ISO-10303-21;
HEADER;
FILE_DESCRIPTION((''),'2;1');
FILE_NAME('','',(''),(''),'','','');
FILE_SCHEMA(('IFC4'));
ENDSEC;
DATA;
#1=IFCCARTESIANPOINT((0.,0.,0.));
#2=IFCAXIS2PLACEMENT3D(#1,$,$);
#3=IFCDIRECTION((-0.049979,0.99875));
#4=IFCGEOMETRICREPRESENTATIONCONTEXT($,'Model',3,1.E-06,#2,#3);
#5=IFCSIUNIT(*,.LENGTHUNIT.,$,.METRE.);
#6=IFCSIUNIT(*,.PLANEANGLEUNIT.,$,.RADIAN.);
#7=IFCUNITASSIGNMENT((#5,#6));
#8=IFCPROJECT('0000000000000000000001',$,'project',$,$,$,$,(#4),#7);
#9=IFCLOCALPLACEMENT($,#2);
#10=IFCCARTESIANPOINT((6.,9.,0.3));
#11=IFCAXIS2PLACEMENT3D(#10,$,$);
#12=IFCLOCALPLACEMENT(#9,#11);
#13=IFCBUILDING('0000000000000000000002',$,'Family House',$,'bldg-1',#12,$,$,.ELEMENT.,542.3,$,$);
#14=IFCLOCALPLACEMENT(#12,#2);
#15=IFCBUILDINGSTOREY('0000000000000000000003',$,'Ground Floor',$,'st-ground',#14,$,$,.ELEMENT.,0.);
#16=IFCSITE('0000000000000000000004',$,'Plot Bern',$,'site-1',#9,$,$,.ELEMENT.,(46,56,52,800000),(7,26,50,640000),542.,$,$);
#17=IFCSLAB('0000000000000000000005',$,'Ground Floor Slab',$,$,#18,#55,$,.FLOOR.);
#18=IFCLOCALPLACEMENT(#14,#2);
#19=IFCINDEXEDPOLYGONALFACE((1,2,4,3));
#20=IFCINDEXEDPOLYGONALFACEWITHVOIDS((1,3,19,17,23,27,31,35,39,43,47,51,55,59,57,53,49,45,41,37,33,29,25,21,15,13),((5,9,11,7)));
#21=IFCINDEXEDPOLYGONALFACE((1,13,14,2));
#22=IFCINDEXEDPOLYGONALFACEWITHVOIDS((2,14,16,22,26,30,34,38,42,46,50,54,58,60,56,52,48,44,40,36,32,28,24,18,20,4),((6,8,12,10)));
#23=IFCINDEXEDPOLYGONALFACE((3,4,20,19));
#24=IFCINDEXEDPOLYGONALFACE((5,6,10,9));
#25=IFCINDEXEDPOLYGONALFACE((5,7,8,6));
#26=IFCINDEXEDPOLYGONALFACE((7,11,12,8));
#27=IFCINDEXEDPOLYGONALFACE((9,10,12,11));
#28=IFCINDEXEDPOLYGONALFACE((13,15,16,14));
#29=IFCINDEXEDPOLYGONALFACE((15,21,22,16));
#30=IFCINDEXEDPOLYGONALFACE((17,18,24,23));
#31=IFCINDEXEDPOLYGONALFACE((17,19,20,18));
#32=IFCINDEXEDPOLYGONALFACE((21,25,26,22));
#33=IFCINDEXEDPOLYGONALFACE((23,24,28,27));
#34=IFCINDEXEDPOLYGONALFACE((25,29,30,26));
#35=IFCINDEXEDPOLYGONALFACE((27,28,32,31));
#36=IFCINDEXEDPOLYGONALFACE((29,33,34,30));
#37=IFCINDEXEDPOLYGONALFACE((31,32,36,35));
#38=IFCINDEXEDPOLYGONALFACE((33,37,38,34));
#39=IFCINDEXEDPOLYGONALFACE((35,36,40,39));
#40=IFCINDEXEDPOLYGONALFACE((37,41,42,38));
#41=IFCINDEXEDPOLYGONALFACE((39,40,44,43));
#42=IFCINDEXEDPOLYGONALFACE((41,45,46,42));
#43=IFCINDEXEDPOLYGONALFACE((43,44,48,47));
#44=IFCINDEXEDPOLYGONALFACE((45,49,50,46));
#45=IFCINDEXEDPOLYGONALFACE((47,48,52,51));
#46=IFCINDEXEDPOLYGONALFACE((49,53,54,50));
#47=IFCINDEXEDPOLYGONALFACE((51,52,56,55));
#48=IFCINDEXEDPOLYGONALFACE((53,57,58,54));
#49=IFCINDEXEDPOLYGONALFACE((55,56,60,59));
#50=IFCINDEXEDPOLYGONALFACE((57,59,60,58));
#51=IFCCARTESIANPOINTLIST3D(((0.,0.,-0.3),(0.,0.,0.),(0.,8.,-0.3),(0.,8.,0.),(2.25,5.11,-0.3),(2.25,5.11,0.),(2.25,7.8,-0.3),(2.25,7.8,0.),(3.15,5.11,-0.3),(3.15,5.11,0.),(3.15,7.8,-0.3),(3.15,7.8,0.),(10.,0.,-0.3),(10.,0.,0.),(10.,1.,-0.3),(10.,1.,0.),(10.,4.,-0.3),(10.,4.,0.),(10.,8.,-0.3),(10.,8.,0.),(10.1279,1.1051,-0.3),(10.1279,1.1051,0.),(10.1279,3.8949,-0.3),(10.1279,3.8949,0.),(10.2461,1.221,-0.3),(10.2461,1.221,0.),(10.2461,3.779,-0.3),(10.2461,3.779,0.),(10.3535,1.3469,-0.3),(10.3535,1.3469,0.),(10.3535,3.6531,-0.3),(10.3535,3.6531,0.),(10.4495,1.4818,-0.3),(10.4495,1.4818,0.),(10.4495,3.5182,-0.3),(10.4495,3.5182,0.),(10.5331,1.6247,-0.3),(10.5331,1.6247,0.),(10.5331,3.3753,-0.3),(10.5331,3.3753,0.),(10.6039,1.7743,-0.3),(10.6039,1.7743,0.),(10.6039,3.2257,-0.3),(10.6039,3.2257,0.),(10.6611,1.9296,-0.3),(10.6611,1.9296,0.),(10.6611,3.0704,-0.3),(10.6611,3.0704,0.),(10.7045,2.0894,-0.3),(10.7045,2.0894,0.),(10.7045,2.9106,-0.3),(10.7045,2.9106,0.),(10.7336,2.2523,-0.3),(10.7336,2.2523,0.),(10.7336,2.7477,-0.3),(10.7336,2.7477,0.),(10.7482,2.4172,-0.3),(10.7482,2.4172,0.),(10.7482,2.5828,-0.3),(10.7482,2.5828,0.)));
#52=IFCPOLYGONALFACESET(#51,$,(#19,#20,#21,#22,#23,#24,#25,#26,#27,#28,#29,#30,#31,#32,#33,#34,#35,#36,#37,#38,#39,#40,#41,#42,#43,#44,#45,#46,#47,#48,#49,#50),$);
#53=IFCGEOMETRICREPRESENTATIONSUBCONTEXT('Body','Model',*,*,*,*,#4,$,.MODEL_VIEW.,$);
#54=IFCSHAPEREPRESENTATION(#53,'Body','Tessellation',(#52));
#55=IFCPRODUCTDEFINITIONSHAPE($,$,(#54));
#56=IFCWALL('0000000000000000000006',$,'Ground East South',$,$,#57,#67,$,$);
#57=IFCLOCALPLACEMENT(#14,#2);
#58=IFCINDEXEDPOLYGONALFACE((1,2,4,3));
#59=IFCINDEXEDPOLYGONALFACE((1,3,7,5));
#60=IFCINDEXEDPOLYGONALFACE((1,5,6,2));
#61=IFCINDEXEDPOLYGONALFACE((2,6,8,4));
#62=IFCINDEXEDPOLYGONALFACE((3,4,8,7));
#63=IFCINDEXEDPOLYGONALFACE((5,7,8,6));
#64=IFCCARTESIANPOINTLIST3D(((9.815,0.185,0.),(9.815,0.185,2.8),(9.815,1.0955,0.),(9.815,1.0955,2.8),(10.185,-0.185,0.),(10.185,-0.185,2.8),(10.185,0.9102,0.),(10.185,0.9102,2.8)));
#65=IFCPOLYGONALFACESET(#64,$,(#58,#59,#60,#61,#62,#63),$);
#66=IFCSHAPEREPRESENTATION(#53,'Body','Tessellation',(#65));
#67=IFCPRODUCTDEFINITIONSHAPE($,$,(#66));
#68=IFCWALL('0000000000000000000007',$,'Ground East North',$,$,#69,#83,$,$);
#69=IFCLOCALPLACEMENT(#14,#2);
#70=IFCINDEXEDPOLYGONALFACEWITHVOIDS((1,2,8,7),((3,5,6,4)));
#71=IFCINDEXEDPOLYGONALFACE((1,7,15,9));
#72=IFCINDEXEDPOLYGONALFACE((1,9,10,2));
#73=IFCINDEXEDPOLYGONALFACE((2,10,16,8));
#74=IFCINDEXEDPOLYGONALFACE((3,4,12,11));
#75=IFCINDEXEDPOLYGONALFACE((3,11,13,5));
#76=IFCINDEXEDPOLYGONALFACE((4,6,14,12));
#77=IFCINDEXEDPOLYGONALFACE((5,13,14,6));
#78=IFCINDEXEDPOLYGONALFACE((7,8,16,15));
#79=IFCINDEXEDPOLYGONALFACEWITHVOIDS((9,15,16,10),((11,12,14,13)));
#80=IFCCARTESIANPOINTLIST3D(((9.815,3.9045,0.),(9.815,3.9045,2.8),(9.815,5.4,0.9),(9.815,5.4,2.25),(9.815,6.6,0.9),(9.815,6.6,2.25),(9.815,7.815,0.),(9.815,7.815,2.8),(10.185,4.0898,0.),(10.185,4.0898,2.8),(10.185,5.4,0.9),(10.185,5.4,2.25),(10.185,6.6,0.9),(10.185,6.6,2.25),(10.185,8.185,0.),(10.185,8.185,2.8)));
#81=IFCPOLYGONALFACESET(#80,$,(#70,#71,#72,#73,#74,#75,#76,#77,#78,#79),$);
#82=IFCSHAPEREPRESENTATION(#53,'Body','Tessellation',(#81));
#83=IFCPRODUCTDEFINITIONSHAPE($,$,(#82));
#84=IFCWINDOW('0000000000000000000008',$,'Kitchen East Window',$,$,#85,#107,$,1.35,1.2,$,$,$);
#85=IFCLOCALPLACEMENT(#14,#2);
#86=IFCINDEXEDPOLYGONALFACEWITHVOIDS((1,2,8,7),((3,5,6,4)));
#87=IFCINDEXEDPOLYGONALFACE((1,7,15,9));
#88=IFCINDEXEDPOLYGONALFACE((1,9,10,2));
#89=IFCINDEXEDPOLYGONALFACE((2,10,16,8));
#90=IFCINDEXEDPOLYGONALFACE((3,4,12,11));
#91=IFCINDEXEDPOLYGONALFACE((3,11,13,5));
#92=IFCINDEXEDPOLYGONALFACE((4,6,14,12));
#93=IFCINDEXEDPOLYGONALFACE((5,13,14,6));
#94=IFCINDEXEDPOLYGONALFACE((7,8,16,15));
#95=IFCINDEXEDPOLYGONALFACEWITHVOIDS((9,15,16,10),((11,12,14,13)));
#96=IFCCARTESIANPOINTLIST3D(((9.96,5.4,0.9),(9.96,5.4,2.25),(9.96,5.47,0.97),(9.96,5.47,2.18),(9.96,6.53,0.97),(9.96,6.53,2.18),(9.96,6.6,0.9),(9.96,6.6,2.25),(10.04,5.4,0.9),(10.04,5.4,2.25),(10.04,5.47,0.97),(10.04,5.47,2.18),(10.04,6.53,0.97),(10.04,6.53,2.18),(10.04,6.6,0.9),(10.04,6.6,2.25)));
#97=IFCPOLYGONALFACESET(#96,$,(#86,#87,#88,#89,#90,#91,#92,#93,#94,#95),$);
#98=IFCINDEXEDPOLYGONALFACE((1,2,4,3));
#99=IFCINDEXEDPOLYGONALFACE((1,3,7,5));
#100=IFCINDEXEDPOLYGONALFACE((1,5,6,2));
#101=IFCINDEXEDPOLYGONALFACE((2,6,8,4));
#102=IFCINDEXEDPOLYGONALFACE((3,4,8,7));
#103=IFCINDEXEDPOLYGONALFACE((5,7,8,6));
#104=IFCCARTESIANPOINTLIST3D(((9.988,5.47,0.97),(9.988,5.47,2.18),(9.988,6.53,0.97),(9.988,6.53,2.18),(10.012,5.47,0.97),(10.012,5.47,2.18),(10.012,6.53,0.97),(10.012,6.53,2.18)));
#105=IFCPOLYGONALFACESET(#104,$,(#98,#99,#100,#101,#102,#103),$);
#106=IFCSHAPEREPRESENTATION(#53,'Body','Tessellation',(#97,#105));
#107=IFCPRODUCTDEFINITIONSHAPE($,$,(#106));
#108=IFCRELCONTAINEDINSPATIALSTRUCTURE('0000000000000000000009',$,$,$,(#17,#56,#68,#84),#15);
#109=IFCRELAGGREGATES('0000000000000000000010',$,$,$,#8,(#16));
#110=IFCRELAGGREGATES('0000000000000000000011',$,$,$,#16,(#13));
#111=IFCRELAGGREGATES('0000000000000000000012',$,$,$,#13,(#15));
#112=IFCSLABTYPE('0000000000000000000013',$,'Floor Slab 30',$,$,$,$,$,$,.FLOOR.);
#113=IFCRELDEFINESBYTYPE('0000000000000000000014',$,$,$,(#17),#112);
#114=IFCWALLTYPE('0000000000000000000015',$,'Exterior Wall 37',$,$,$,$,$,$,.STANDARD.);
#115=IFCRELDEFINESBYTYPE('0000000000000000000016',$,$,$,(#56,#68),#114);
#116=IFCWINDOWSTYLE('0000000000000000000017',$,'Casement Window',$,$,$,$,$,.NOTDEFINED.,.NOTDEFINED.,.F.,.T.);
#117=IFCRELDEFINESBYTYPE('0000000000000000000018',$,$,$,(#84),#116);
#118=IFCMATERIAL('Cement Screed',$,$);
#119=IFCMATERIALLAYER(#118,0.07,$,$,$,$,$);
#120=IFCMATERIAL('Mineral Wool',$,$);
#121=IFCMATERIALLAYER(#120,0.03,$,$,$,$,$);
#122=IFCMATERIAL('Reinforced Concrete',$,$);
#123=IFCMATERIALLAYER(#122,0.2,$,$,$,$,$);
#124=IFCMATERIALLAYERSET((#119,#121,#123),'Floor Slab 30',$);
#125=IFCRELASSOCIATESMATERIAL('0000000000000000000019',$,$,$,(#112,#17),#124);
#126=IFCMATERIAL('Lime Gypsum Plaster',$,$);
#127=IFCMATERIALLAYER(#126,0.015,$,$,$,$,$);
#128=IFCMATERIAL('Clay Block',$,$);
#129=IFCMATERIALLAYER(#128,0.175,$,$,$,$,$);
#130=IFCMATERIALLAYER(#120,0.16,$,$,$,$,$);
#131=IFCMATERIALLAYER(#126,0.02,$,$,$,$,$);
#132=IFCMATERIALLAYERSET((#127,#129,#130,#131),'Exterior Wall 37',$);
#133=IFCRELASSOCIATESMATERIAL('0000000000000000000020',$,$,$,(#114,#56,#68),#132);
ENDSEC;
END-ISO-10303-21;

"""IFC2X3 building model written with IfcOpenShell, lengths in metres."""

from ifc_helpers import new_model, si_unit, point, direction, frame, frame_2d, origin, origin_2d, place, context, subcontext, project, spatial, polyline, circle_curve, trimmed, segment, composite_curve, rectangle, outline, extrude, material, layer, layer_set, layer_usage, type_object, element, fill, save


model = new_model("IFC2X3")

# Units and contexts
model_context = context("Model", 3, precision=1e-06, world=origin(), true_north=direction((-0.049979, 0.99875)))
body_context = subcontext(model_context, "Body", "Model", "MODEL_VIEW")
ifc_project = project(units=[si_unit("LENGTHUNIT", "METRE"), si_unit("PLANEANGLEUNIT", "RADIAN")], contexts=[model_context])

# Site, building, storey
site_placement = place(None, origin())
site = spatial("IfcSite", under=ifc_project, at=site_placement, Name="Plot Bern", ObjectType="site-1", CompositionType="ELEMENT", RefLatitude=(46, 56, 52, 800000), RefLongitude=(7, 26, 50, 640000), RefElevation=542.0)
building_placement = place(site_placement, frame((6.0, 9.0, 0.3)))
building = spatial("IfcBuilding", under=site, at=building_placement, Name="Family House", ObjectType="bldg-1", CompositionType="ELEMENT", ElevationOfRefHeight=542.3)
storey_placement = place(building_placement, origin())
storey = spatial("IfcBuildingStorey", under=building, at=storey_placement, Name="Ground Floor", ObjectType="st-ground", CompositionType="ELEMENT", Elevation=0.0)

# Slab
ifc_material_1 = material(Name="Cement Screed")
ifc_layer_1 = layer(ifc_material_1, 0.07)
ifc_material_2 = material(Name="Mineral Wool")
ifc_layer_2 = layer(ifc_material_2, 0.03)
ifc_material_3 = material(Name="Reinforced Concrete")
ifc_layer_3 = layer(ifc_material_3, 0.2)
ifc_layer_set_1 = layer_set([ifc_layer_1, ifc_layer_2, ifc_layer_3], Name="Floor Slab 30")
ifc_layer_usage_1 = layer_usage(ifc_layer_set_1, "AXIS3", "NEGATIVE", 0.3)
slab_type = type_object("IfcSlabType", Name="Floor Slab 30", PredefinedType="FLOOR", material=ifc_layer_set_1)
slab_placement = place(storey_placement, frame((0.0, 0.0, -0.3)))
element("IfcSlab", 1, at=slab_placement, inside=storey, type_object=slab_type, material=ifc_layer_usage_1, Name="Ground Floor Slab", PredefinedType="FLOOR", context=body_context, shape_type="SweptSolid", body=[
    extrude(outline(composite_curve([segment(polyline([(0.0, 0.0), (10.0, 0.0)]), True, "CONTINUOUS"), segment(polyline([(10.0, 0.0), (10.0, 1.0)]), True, "CONTINUOUS"), segment(trimmed(circle_curve(frame_2d((8.875, 2.5)), 1.875), [point((10.0, 1.0))], [point((10.0, 4.0))], True, "CARTESIAN"), True, "CONTINUOUS"), segment(polyline([(10.0, 4.0), (10.0, 8.0)]), True, "CONTINUOUS"), segment(polyline([(10.0, 8.0), (0.0, 8.0)]), True, "CONTINUOUS"), segment(polyline([(0.0, 8.0), (0.0, 0.0)]), True, "CONTINUOUS")], self_intersect=False), holes=[polyline([(2.25, 5.11), (2.25, 7.8), (3.15, 7.8), (3.15, 5.11), (2.25, 5.11)])]), origin(), (0.0, 0.0, 1.0), 0.3),
])

# Shared definitions
ifc_material_4 = material(Name="Lime Gypsum Plaster")
ifc_layer_4 = layer(ifc_material_4, 0.015)
ifc_material_5 = material(Name="Clay Block")
ifc_layer_5 = layer(ifc_material_5, 0.175)
ifc_layer_6 = layer(ifc_material_2, 0.16)
ifc_layer_7 = layer(ifc_material_4, 0.02)
ifc_layer_set_2 = layer_set([ifc_layer_4, ifc_layer_5, ifc_layer_6, ifc_layer_7], Name="Exterior Wall 37")
wall_type_1 = type_object("IfcWallType", Name="Exterior Wall 37", PredefinedType="STANDARD", material=ifc_layer_set_2)

# Wall
ifc_layer_usage_2 = layer_usage(ifc_layer_set_2, "AXIS2", "NEGATIVE", 0.185)
wall_1_placement = place(storey_placement, origin())
element("IfcWall", 2, at=wall_1_placement, inside=storey, type_object=wall_type_1, material=ifc_layer_usage_2, Name="Ground East South", context=body_context, shape_type="SweptSolid", body=[
    extrude(outline(polyline([(10.185, -0.185), (10.185, 0.9102), (9.815, 1.0955), (9.815, 0.185), (10.185, -0.185)])), origin(), (0.0, 0.0, 1.0), 2.8),
])

# Wall, opening, window
ifc_layer_usage_3 = layer_usage(ifc_layer_set_2, "AXIS2", "NEGATIVE", 0.185)
wall_2_placement = place(storey_placement, origin())
wall_2 = element("IfcWall", 3, at=wall_2_placement, inside=storey, type_object=wall_type_1, material=ifc_layer_usage_3, Name="Ground East North", context=body_context, shape_type="SweptSolid", body=[
    extrude(outline(polyline([(10.185, 4.0898), (10.185, 8.185), (9.815, 7.815), (9.815, 3.9045), (10.185, 4.0898)])), origin(), (0.0, 0.0, 1.0), 2.8),
])
opening_1_placement = place(wall_2_placement, frame((10.0, 6.0, 0.9), z_axis=(0.0, 0.0, 1.0), x_axis=(0.0, 1.0, 0.0)))
opening_1 = element("IfcOpeningElement", 4, at=opening_1_placement, cuts=wall_2, context=body_context, shape_type="SweptSolid", body=[
    extrude(rectangle(XDim=1.2, YDim=0.37, at=origin_2d()), origin(), (0.0, 0.0, 1.0), 1.35),
])
window_style_1 = type_object("IfcWindowStyle", Name="Casement Window", ConstructionType="NOTDEFINED", OperationType="NOTDEFINED", ParameterTakesPrecedence=False, Sizeable=True)
window_1_placement = place(opening_1_placement, frame((0.0, 0.0, 0.0), z_axis=(0.0, -1.0, 0.0), x_axis=(1.0, 0.0, 0.0)))
window_1 = element("IfcWindow", 5, at=window_1_placement, inside=storey, type_object=window_style_1, Name="Kitchen East Window", OverallHeight=1.35, OverallWidth=1.2, context=body_context, shape_type="SweptSolid", body=[
    extrude(outline(polyline([(-0.6, 0.0), (0.6, 0.0), (0.6, 1.35), (-0.6, 1.35), (-0.6, 0.0)]), holes=[polyline([(-0.53, 0.07), (0.53, 0.07), (0.53, 1.28), (-0.53, 1.28), (-0.53, 0.07)])]), frame((0.0, 0.0, -0.04)), (0.0, 0.0, 1.0), 0.08),
    extrude(rectangle(XDim=1.06, YDim=1.21, at=frame_2d((0.0, 0.675))), frame((0.0, 0.0, -0.012)), (0.0, 0.0, 1.0), 0.024),
])
fill(opening_1, window_1)

save(model, "model.ifc")
